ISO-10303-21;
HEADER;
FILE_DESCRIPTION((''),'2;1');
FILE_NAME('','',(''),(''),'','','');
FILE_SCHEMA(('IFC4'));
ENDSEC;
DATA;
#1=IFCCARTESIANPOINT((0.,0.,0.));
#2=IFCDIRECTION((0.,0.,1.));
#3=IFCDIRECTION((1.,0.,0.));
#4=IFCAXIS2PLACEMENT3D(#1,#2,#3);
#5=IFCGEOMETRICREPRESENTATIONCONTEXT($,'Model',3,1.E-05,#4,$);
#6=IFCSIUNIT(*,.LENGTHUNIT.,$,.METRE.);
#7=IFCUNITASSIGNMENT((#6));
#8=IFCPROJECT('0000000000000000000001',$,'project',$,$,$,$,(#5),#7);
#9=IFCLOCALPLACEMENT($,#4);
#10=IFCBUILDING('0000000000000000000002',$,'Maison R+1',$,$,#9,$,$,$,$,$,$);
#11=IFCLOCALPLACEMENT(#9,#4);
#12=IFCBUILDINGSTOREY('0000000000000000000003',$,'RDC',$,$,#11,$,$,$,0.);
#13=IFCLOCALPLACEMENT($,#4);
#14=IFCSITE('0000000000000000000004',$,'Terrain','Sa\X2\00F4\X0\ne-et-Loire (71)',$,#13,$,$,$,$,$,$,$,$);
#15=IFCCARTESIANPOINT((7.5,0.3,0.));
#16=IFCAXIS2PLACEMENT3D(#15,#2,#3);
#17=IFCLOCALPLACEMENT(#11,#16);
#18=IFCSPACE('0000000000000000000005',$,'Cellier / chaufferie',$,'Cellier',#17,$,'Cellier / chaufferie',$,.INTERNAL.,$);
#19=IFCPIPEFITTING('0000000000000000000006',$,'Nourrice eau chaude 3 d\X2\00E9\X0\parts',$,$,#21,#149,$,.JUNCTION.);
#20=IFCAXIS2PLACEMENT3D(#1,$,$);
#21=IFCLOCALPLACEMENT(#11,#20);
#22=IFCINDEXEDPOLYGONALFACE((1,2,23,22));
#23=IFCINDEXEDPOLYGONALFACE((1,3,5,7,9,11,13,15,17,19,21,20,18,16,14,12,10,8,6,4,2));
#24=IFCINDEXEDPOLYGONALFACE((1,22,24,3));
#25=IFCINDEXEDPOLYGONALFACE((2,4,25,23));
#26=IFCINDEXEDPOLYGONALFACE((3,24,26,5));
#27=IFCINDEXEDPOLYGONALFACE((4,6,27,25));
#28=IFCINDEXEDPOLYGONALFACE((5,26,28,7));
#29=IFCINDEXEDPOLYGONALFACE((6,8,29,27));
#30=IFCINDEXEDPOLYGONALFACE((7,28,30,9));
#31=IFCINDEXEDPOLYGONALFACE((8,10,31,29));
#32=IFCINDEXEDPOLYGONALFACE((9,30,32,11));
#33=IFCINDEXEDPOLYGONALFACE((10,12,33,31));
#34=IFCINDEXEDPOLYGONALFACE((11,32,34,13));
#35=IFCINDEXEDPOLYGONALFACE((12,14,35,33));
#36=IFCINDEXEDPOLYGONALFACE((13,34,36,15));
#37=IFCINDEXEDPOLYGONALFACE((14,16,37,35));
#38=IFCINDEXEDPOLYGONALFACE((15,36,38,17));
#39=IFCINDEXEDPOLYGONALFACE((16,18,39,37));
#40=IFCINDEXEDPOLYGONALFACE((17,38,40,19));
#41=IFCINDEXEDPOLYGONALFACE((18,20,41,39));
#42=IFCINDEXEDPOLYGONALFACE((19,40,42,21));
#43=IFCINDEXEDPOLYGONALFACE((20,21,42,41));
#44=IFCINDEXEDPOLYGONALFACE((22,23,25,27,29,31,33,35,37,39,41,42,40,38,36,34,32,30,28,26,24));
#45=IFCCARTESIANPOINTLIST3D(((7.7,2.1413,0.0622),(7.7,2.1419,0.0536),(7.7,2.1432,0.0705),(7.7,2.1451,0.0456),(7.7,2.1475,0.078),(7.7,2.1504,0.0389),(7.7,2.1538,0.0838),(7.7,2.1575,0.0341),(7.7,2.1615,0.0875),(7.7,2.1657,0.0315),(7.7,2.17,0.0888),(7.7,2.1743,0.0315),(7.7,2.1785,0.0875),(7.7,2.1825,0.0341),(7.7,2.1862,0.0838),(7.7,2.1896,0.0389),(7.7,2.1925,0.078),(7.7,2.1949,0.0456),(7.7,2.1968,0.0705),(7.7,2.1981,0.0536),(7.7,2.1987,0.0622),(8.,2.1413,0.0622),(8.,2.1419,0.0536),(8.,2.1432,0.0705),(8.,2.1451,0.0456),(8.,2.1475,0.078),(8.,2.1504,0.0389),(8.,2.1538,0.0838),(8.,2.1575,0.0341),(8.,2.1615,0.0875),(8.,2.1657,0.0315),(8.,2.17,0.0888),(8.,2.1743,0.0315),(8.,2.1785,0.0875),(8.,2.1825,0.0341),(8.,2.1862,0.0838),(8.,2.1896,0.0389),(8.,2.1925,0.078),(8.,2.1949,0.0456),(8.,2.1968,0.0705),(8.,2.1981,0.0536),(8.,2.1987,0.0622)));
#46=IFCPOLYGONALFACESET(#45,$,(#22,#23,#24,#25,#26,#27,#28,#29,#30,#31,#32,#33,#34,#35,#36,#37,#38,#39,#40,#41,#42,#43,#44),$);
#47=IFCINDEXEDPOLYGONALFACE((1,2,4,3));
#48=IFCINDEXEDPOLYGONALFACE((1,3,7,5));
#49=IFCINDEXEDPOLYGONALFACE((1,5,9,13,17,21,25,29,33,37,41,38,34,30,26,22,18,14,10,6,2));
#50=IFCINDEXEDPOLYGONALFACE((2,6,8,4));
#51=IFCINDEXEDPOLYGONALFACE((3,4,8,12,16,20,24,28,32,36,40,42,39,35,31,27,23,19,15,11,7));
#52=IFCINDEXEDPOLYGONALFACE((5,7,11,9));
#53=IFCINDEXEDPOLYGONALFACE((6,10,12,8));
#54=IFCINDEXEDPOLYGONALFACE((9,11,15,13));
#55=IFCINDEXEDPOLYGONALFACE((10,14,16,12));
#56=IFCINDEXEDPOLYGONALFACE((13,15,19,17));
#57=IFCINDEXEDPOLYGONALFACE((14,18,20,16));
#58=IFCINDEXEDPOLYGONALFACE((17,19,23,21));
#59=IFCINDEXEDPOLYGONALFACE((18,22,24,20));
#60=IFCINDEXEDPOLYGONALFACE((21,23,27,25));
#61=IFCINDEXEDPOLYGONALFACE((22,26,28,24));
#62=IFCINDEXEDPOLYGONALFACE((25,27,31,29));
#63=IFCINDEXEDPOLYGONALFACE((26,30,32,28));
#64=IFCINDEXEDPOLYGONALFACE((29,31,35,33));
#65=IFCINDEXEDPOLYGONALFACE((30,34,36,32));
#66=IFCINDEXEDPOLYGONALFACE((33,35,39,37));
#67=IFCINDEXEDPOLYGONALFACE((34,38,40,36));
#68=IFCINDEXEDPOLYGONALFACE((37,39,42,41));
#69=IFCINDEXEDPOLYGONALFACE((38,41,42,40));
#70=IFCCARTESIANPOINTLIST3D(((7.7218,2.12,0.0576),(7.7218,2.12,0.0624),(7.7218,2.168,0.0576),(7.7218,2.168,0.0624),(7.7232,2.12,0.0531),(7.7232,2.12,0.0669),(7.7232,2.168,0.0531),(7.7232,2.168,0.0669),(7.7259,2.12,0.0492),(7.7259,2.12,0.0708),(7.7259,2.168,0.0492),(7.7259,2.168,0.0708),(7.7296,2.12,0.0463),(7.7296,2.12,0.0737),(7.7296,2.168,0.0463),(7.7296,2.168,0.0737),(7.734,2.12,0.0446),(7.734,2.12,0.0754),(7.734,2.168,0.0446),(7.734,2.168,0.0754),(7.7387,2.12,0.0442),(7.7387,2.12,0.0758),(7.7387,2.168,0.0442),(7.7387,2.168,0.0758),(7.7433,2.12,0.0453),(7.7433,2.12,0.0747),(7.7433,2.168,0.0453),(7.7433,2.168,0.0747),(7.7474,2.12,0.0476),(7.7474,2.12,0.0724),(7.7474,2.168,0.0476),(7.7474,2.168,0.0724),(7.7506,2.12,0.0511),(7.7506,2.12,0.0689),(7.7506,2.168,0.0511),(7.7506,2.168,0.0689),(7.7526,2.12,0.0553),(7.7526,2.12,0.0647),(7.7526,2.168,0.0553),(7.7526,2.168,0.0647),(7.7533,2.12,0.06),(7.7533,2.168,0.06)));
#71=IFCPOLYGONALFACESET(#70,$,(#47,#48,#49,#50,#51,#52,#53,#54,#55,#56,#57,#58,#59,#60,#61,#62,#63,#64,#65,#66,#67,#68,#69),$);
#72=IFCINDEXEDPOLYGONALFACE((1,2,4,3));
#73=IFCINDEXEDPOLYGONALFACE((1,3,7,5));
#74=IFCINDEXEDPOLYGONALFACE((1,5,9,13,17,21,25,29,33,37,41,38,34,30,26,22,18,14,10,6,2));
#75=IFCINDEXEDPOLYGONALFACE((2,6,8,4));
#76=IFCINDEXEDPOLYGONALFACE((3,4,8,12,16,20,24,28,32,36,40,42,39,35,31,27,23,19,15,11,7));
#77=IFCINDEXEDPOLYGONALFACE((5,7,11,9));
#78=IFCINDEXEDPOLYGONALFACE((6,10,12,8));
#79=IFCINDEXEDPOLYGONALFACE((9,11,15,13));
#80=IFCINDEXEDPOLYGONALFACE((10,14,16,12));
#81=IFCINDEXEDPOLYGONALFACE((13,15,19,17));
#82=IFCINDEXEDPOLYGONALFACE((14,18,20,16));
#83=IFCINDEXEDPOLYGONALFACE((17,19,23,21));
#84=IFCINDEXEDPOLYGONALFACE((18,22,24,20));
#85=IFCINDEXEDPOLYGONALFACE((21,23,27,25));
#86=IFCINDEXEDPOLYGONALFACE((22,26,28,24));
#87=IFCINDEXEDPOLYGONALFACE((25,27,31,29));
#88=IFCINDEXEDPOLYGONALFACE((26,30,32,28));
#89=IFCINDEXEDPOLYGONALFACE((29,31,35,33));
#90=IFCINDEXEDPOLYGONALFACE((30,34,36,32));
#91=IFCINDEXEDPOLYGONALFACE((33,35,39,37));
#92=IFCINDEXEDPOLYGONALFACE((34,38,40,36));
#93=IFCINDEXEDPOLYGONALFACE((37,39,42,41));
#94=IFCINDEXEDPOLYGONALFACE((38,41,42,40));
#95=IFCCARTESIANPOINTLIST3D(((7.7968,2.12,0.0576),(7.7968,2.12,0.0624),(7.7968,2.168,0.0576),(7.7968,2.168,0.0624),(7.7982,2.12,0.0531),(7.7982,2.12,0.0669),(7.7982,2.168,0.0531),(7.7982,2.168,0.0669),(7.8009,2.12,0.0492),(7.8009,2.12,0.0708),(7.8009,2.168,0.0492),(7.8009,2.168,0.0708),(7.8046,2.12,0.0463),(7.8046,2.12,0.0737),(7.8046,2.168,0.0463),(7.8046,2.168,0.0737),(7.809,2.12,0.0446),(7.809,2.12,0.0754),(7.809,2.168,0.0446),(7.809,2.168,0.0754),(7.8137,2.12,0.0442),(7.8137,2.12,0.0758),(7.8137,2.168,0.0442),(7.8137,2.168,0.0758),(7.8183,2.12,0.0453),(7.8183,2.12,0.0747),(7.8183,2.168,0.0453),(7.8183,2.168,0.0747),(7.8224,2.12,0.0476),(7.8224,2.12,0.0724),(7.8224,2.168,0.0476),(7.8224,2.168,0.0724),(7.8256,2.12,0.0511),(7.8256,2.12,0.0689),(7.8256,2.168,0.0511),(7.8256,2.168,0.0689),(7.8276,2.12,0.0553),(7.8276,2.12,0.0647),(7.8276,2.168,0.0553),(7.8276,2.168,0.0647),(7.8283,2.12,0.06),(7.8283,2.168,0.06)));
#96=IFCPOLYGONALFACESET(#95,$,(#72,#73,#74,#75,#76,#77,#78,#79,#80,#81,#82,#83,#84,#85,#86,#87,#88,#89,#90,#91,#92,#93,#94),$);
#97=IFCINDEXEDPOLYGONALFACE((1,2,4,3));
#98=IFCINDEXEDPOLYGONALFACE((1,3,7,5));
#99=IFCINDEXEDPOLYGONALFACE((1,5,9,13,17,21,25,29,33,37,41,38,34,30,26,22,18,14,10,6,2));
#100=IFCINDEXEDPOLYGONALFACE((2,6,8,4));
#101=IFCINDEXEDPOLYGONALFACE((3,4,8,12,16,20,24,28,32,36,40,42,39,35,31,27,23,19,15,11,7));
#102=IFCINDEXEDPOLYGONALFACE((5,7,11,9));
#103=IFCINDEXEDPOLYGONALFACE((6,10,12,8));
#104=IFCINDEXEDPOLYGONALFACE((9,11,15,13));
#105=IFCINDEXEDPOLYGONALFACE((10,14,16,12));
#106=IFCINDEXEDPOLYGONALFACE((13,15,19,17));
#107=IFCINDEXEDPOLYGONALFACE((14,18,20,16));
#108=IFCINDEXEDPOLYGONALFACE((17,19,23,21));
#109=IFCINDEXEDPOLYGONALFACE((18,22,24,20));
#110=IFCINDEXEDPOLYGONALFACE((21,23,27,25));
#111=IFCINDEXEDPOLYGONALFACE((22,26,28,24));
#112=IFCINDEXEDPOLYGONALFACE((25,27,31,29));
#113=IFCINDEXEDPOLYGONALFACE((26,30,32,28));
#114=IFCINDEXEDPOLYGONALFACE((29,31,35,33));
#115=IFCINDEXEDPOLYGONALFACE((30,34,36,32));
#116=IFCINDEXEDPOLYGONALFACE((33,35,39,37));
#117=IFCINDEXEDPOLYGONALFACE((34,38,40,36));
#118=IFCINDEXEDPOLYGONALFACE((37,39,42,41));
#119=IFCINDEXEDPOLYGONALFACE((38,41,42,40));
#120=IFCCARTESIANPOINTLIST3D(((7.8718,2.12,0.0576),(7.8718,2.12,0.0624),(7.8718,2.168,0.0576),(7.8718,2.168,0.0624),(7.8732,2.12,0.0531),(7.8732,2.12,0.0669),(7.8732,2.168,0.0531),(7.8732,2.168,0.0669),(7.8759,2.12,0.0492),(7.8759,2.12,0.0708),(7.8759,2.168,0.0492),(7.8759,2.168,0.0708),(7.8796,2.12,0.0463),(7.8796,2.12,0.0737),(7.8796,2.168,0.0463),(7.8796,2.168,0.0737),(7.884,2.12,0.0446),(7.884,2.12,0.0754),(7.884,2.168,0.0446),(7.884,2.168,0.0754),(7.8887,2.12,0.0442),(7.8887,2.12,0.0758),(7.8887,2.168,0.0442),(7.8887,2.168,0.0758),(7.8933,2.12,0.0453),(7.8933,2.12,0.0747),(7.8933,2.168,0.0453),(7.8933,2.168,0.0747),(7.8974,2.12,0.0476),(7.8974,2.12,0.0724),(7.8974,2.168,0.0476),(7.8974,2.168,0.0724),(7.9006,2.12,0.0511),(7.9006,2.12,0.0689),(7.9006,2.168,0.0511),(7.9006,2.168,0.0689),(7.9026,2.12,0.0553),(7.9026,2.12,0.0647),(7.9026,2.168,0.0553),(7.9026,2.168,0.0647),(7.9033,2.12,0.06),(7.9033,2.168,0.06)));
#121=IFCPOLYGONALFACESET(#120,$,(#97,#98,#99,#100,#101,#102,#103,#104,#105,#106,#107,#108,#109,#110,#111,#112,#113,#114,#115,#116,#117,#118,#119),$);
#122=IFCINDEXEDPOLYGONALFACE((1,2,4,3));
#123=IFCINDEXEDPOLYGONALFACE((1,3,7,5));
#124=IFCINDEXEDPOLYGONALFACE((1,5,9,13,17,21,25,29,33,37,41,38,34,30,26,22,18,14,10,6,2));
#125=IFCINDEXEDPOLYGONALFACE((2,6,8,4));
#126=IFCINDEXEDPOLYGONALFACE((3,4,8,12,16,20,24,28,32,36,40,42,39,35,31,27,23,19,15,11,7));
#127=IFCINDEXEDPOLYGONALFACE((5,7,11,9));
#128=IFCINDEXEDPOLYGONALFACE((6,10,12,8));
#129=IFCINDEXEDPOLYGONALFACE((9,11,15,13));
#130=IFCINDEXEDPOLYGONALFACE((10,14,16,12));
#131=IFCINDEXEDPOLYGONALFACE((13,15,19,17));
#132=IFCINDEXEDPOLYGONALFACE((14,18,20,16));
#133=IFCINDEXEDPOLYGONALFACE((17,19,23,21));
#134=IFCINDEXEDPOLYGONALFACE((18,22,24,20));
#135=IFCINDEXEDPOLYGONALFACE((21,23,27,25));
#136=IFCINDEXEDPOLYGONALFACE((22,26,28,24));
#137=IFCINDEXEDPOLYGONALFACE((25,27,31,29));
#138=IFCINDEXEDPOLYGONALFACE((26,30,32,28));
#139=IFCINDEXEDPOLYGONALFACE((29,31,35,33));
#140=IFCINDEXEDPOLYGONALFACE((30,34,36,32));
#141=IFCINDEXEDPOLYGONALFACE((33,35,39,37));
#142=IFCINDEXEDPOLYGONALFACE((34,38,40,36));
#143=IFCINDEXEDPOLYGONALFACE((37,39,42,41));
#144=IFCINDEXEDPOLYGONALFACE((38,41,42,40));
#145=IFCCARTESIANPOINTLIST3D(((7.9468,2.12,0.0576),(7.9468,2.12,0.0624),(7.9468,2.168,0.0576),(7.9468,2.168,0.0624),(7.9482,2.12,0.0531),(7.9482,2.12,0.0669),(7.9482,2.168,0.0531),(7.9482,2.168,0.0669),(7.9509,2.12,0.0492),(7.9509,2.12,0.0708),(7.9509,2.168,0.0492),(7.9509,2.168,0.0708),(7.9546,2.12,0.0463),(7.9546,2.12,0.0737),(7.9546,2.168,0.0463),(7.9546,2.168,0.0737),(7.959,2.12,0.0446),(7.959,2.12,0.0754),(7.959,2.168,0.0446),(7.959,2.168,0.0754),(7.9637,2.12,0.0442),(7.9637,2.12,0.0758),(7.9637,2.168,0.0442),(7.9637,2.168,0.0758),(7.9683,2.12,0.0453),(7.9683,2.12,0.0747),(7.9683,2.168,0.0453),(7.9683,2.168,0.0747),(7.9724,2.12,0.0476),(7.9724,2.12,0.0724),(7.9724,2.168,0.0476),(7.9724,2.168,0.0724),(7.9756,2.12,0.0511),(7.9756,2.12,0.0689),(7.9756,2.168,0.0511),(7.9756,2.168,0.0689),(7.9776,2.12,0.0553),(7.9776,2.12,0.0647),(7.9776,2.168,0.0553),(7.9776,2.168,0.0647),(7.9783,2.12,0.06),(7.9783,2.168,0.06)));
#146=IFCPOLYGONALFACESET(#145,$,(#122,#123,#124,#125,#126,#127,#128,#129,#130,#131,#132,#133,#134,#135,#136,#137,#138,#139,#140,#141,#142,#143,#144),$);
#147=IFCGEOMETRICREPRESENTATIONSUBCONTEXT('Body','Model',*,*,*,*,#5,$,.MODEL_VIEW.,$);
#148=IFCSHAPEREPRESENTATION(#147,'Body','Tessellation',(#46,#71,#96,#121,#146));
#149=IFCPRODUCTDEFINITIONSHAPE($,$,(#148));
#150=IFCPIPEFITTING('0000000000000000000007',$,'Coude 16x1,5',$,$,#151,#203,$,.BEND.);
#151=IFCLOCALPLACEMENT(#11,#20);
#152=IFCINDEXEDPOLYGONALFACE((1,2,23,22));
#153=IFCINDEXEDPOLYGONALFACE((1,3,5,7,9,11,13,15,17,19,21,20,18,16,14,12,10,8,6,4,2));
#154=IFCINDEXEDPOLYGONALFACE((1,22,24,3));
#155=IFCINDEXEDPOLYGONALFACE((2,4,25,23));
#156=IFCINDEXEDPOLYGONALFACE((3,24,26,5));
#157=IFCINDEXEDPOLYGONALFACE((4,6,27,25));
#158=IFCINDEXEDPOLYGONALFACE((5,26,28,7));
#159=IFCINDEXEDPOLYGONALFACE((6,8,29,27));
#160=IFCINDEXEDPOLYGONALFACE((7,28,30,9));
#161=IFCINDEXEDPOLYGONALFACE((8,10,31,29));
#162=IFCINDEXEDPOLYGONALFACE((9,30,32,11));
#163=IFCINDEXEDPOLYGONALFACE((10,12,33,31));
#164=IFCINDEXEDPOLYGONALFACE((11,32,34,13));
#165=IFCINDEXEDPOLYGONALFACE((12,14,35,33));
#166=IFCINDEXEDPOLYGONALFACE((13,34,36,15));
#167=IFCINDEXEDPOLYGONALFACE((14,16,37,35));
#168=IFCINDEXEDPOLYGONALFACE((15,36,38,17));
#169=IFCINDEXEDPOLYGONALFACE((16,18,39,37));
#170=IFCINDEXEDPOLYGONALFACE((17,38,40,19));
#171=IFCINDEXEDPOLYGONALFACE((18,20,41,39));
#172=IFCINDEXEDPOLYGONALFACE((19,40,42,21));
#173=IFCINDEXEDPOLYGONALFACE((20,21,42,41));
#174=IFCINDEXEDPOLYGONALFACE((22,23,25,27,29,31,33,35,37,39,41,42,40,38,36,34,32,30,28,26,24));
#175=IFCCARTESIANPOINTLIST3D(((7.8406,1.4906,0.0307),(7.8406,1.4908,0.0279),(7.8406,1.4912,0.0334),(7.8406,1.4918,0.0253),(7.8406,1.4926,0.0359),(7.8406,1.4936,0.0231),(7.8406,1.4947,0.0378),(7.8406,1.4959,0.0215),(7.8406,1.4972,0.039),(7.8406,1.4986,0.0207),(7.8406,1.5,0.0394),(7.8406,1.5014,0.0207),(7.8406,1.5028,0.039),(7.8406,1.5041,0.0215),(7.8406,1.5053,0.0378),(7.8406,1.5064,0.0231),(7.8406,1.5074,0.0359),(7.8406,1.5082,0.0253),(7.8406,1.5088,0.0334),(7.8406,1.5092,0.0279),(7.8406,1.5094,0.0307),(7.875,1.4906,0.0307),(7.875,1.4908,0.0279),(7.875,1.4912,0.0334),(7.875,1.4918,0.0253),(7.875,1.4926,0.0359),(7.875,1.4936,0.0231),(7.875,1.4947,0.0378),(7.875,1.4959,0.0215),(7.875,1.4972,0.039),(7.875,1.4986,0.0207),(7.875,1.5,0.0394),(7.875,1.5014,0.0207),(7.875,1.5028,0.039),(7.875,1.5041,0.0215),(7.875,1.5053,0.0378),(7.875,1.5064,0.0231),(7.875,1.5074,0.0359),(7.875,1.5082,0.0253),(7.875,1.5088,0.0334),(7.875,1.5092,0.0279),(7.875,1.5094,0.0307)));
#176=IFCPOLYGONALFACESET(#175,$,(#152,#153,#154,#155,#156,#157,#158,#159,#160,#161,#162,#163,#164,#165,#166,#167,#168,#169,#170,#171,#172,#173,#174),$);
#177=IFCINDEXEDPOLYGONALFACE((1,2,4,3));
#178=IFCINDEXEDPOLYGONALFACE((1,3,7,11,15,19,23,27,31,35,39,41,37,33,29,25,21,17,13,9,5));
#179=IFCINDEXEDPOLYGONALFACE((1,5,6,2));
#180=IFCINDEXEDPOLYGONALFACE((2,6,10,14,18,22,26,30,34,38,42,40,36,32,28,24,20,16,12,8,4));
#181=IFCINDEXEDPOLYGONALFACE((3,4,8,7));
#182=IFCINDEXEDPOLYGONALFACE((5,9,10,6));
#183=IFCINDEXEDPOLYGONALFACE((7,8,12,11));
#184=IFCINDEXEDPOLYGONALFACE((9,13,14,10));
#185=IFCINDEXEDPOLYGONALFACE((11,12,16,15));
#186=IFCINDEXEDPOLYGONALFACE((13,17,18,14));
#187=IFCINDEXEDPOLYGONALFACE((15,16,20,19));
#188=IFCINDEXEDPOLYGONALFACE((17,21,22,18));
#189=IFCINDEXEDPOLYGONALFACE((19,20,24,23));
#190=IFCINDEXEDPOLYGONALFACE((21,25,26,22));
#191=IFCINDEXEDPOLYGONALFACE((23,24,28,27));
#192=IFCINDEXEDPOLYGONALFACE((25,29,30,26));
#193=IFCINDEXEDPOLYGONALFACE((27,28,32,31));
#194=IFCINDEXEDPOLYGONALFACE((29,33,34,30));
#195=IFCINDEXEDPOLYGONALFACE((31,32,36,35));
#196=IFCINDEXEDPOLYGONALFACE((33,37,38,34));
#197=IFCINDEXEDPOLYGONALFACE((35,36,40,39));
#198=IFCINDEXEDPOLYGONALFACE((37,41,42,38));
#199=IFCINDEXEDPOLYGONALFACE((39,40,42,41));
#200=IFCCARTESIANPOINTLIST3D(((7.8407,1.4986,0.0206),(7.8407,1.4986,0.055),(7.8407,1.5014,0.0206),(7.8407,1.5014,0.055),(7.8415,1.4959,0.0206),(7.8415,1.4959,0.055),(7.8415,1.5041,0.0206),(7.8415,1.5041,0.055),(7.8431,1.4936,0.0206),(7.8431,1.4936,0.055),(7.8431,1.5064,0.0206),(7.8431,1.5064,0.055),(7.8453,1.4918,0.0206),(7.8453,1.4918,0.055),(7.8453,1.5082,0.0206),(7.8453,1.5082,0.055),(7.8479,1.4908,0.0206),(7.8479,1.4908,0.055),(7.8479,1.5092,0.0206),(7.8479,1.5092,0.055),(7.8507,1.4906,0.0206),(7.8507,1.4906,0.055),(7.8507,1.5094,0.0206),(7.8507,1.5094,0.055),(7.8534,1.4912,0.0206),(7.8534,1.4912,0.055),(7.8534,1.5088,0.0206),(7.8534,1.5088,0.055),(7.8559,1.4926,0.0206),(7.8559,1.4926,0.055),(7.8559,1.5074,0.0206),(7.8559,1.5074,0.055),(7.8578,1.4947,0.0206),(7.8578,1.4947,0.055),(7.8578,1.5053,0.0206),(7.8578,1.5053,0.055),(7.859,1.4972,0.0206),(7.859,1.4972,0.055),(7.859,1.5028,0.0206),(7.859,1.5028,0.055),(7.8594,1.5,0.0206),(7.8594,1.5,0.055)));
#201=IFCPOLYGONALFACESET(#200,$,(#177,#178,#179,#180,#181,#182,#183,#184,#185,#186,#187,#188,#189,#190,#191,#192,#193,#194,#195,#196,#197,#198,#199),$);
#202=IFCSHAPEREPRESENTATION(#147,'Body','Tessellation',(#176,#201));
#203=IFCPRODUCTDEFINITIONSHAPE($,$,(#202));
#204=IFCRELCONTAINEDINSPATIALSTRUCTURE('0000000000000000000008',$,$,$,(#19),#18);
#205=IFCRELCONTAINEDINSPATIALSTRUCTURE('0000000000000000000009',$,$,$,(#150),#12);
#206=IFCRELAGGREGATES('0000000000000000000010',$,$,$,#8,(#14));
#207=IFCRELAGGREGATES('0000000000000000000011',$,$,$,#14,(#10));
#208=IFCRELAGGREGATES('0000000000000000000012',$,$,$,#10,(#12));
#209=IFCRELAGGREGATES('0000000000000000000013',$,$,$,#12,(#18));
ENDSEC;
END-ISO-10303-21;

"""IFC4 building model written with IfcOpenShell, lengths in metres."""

from ifc_helpers import new_model, si_unit, frame, origin_with_axes, place, context, subcontext, project, spatial, circle, extrude, element, save


model = new_model("IFC4")

# Units and contexts
model_context = context("Model", 3, precision=1e-05, world=origin_with_axes())
body_context = subcontext(model_context, "Body", "Model", "MODEL_VIEW")
ifc_project = project(units=[si_unit("LENGTHUNIT", "METRE")], contexts=[model_context])

# Site, building, storey
site_placement = place(None, origin_with_axes())
site = spatial("IfcSite", under=ifc_project, at=site_placement, Name="Terrain", Description="Saône-et-Loire (71)")
building_placement = place(None, origin_with_axes())
building = spatial("IfcBuilding", under=site, at=building_placement, Name="Maison R+1")
storey_placement = place(building_placement, origin_with_axes())
storey = spatial("IfcBuildingStorey", under=building, at=storey_placement, Name="RDC", Elevation=0.0)

# Shared definitions
space_1_placement = place(storey_placement, frame((7.5, 0.3, 0.0), z_axis=(0.0, 0.0, 1.0), x_axis=(1.0, 0.0, 0.0)))
space_1 = spatial("IfcSpace", under=storey, at=space_1_placement, Name="Cellier / chaufferie", ObjectType="Cellier", LongName="Cellier / chaufferie", PredefinedType="INTERNAL")

# Pipe fittings
pipe_fitting_1_placement = place(space_1_placement, frame((0.2, 1.82, 0.02), z_axis=(0.0, 0.0, 1.0), x_axis=(1.0, 0.0, 0.0)))
element("IfcPipeFitting", 1, at=pipe_fitting_1_placement, inside=space_1, Name="Nourrice eau chaude 3 départs", PredefinedType="JUNCTION", context=body_context, shape_type="SweptSolid", body=[
    extrude(circle(Radius=0.0288), frame((0.0, 0.05, 0.04), z_axis=(1.0, 0.0, 0.0), x_axis=(0.0, 0.0, 1.0)), (0.0, 0.0, 1.0), 0.3),
    extrude(circle(Radius=0.0158), frame((0.0375, 0.0, 0.04), z_axis=(0.0, 1.0, 0.0), x_axis=(1.0, 0.0, 0.0)), (0.0, 0.0, 1.0), 0.048),
    extrude(circle(Radius=0.0158), frame((0.1125, 0.0, 0.04), z_axis=(0.0, 1.0, 0.0), x_axis=(1.0, 0.0, 0.0)), (0.0, 0.0, 1.0), 0.048),
    extrude(circle(Radius=0.0158), frame((0.1875, 0.0, 0.04), z_axis=(0.0, 1.0, 0.0), x_axis=(1.0, 0.0, 0.0)), (0.0, 0.0, 1.0), 0.048),
    extrude(circle(Radius=0.0158), frame((0.2625, 0.0, 0.04), z_axis=(0.0, 1.0, 0.0), x_axis=(1.0, 0.0, 0.0)), (0.0, 0.0, 1.0), 0.048),
])
pipe_fitting_2_placement = place(storey_placement, frame((7.85, 1.5, 0.03), z_axis=(0.0, 0.0, 1.0), x_axis=(1.0, 0.0, 0.0)))
element("IfcPipeFitting", 2, at=pipe_fitting_2_placement, inside=storey, Name="Coude 16x1,5", PredefinedType="BEND", context=body_context, shape_type="SweptSolid", body=[
    extrude(circle(Radius=0.0094), frame((-0.0094, 0.0, 0.0), z_axis=(1.0, 0.0, 0.0), x_axis=(0.0, 0.0, 1.0)), (0.0, 0.0, 1.0), 0.0344),
    extrude(circle(Radius=0.0094), frame((0.0, 0.0, -0.0094), z_axis=(0.0, 0.0, 1.0), x_axis=(1.0, 0.0, 0.0)), (0.0, 0.0, 1.0), 0.0344),
])

save(model, "model.ifc")
